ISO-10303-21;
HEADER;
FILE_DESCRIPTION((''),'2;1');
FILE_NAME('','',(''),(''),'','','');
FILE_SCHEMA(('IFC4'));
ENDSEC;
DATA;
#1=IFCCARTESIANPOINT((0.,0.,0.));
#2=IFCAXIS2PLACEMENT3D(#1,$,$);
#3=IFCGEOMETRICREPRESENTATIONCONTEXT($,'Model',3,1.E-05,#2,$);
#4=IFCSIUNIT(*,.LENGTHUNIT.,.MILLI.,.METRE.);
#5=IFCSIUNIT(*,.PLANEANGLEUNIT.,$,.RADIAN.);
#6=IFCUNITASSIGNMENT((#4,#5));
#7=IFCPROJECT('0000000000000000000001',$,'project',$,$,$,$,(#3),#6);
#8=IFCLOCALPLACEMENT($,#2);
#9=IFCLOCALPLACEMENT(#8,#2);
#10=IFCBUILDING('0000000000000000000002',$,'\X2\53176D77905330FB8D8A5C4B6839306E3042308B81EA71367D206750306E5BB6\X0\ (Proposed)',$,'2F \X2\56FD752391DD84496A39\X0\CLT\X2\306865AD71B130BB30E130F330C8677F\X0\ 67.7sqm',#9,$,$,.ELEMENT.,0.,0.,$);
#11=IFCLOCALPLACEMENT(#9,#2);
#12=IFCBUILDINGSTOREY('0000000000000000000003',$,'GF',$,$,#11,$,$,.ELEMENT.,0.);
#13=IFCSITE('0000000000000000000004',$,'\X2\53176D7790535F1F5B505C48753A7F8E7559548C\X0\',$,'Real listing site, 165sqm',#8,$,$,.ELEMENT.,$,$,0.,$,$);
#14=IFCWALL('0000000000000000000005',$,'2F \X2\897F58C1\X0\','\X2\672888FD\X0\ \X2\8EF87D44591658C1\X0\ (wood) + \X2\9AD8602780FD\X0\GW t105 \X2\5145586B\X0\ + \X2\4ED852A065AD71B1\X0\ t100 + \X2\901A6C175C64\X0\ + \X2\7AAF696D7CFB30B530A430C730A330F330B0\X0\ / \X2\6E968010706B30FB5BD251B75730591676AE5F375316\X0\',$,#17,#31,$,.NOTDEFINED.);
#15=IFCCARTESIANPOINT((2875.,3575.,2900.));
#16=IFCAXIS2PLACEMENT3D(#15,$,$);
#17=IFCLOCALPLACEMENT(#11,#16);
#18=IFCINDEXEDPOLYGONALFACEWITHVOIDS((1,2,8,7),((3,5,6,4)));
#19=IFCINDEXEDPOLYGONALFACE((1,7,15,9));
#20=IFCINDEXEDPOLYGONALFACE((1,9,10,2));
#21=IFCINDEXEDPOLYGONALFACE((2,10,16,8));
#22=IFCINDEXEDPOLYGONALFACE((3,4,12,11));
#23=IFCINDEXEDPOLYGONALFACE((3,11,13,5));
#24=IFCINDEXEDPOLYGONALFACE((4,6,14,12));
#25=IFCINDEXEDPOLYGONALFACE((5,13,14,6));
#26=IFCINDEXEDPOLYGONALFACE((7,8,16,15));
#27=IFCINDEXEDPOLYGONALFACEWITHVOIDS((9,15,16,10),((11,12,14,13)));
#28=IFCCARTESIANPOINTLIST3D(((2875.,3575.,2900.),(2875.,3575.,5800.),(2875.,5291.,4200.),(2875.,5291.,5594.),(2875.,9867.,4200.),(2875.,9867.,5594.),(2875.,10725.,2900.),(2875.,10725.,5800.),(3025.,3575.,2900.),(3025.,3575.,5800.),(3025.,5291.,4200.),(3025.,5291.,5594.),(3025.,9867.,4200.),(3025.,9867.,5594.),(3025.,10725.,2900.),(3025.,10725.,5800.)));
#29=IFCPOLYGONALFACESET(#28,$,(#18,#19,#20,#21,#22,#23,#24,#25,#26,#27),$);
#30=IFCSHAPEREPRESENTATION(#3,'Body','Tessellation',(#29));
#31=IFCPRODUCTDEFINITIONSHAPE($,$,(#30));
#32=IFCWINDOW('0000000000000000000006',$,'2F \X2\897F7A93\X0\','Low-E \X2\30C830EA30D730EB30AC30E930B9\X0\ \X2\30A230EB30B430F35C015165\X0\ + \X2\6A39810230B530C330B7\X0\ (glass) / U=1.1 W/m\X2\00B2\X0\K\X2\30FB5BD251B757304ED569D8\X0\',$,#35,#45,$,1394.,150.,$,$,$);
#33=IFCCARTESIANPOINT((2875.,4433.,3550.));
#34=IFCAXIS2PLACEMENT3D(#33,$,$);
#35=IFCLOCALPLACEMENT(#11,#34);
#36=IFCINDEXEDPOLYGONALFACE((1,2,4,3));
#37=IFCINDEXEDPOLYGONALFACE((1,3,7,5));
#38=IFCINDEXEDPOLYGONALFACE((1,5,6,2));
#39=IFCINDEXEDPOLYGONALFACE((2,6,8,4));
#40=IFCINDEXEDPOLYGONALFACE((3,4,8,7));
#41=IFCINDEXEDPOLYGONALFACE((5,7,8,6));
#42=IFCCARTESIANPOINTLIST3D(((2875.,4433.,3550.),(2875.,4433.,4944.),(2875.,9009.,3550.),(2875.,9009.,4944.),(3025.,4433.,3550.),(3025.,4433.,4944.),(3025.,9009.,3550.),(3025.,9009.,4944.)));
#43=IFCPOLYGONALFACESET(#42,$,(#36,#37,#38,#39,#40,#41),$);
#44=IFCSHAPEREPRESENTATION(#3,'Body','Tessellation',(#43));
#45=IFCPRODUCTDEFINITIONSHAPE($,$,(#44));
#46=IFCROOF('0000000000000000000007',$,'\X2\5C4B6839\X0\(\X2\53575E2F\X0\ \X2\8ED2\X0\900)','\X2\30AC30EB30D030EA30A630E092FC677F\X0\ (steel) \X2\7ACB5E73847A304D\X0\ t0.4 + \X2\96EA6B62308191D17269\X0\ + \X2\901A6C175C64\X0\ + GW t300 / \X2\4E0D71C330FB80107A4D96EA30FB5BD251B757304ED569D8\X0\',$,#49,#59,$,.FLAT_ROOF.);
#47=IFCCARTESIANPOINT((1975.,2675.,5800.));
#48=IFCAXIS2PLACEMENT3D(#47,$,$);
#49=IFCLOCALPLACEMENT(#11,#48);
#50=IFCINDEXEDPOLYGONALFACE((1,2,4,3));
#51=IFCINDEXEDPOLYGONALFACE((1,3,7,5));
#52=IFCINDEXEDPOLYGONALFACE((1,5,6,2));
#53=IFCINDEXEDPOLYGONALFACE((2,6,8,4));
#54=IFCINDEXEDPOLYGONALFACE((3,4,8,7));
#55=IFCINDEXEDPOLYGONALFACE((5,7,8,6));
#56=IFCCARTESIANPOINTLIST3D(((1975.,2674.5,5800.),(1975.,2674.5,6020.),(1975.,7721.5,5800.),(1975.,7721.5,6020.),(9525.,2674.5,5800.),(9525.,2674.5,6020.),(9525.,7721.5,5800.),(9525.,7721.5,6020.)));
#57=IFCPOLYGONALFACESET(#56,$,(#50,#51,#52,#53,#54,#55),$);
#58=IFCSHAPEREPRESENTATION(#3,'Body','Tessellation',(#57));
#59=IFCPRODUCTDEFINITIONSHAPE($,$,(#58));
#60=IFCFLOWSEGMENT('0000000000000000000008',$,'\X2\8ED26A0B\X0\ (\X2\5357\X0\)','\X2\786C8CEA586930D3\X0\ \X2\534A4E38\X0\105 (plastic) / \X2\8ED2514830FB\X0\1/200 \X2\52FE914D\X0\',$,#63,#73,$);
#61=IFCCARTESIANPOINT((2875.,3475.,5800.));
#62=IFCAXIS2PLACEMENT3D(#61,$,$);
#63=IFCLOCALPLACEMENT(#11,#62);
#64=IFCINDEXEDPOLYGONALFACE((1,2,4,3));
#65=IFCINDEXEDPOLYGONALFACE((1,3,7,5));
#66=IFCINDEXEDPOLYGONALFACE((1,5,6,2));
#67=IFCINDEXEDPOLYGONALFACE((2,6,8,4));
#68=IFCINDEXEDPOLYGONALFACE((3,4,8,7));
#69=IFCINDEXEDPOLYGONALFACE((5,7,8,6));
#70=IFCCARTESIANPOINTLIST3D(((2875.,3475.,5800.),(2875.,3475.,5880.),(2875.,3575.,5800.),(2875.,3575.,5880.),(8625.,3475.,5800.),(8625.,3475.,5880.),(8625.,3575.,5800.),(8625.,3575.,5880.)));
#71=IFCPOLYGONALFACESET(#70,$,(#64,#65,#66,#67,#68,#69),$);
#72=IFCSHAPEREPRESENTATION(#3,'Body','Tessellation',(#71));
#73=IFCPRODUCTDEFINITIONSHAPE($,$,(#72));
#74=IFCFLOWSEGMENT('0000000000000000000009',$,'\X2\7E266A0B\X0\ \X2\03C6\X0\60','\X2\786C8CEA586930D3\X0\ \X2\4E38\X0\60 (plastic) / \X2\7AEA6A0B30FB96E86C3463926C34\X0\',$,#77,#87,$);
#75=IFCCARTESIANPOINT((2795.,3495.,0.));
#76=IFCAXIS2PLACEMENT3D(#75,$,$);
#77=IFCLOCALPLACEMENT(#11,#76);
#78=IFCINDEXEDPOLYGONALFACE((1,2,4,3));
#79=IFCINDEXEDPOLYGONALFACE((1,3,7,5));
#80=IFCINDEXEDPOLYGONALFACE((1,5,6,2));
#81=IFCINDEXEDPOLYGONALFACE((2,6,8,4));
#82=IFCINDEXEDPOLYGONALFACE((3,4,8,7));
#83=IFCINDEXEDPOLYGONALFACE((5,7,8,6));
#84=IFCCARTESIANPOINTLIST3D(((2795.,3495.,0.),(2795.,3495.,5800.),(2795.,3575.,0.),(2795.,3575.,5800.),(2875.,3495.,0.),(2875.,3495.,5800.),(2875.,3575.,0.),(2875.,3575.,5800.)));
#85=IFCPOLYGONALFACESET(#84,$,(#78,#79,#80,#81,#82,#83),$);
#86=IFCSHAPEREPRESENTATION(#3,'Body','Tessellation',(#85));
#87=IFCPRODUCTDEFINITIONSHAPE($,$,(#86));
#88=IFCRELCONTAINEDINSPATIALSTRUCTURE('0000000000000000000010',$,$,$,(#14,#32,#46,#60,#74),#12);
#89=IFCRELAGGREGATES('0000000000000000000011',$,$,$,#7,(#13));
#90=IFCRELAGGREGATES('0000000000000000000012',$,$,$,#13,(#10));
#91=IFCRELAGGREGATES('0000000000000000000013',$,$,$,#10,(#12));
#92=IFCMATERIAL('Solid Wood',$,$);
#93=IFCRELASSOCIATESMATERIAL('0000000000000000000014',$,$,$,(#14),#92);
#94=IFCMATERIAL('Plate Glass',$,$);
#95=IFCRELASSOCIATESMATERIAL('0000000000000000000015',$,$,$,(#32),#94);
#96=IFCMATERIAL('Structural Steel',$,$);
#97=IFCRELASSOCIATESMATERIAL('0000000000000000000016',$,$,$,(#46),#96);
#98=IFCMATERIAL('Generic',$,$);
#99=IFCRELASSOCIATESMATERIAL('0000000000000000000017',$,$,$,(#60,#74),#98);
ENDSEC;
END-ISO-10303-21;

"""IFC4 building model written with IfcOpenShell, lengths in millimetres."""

from ifc_helpers import new_model, si_unit, frame, frame_2d, origin, place, context, project, spatial, rectangle, extrude, material, element, fill, save


model = new_model("IFC4")

# Units and contexts
model_context = context("Model", 3, precision=1e-05, world=origin())
ifc_project = project(units=[si_unit("LENGTHUNIT", "METRE", prefix="MILLI"), si_unit("PLANEANGLEUNIT", "RADIAN")], contexts=[model_context])

# Site, building, storey
site_placement = place(None, origin())
site = spatial("IfcSite", under=ifc_project, at=site_placement, Name="北海道弟子屈町美留和", ObjectType="Real listing site, 165sqm", CompositionType="ELEMENT", RefElevation=0.0)
building_placement = place(site_placement, origin())
building = spatial("IfcBuilding", under=site, at=building_placement, Name="北海道・越屋根のある自然素材の家 (Proposed)", ObjectType="2F 国産針葉樹CLTと断熱セメント板 67.7sqm", CompositionType="ELEMENT", ElevationOfRefHeight=0.0, ElevationOfTerrain=0.0)
storey_placement = place(building_placement, origin())
storey = spatial("IfcBuildingStorey", under=building, at=storey_placement, Name="GF", CompositionType="ELEMENT", Elevation=0.0)

# Shared definitions
ifc_material_1 = material(Name="Solid Wood")

# Shared definitions
ifc_material_2 = material(Name="Plate Glass")

# Wall, opening, window
wall_1_placement = place(storey_placement, frame((2875.0, 3575.0, 2900.0)))
wall_1 = element("IfcWall", 1, at=wall_1_placement, inside=storey, material=ifc_material_1, Name="2F 西壁", Description="木製 軸組外壁 (wood) + 高性能GW t105 充填 + 付加断熱 t100 + 通気層 + 窯業系サイディング / 準耐火・寒冷地外皮強化", PredefinedType="NOTDEFINED", context=model_context, shape_type="SweptSolid", body=[
    extrude(rectangle(XDim=150.0, YDim=7150.0, at=frame_2d((75.0, 3575.0))), frame((2875.0, 3575.0, 2900.0)), (0.0, 0.0, 1.0), 2900.0),
])
opening_1_placement = place(storey_placement, frame((2875.0, 4433.0, 3550.0)))
opening_1 = element("IfcOpeningElement", 2, at=opening_1_placement, cuts=wall_1, PredefinedType="NOTDEFINED", context=model_context, shape_type="SweptSolid", body=[
    extrude(rectangle(XDim=150.0, YDim=4576.0, at=frame_2d((75.0, 2288.0))), frame((2875.0, 4433.0, 3550.0)), (0.0, 0.0, 1.0), 1394.0),
])
window_1_placement = place(storey_placement, frame((2875.0, 4433.0, 3550.0)))
window_1 = element("IfcWindow", 3, at=window_1_placement, inside=storey, material=ifc_material_2, Name="2F 西窓", Description="Low-E トリプルガラス アルゴン封入 + 樹脂サッシ (glass) / U=1.1 W/m²K・寒冷地仕様", OverallHeight=1394.0, OverallWidth=150.0, context=model_context, shape_type="SweptSolid", body=[
    extrude(rectangle(XDim=150.0, YDim=4576.0, at=frame_2d((75.0, 2288.0))), frame((2875.0, 4433.0, 3550.0)), (0.0, 0.0, 1.0), 1394.0),
])
fill(opening_1, window_1)

# Roof
ifc_material_3 = material(Name="Structural Steel")
for number, where, name in (
    (4, (1975.0, 2675.0, 5800.0), "屋根(南帯 軒900)"),
):
    element("IfcRoof", number, at=place(storey_placement, frame(where)), inside=storey, material=ifc_material_3, Name=name, Description="ガルバリウム鋼板 (steel) 立平葺き t0.4 + 雪止め金物 + 通気層 + GW t300 / 不燃・耐積雪・寒冷地仕様", PredefinedType="FLAT_ROOF", context=model_context, shape_type="SweptSolid", body=[
        extrude(rectangle(XDim=7550.0, YDim=5047.0, at=frame_2d((3775.0, 2523.0))), frame((1975.0, 2675.0, 5800.0)), (0.0, 0.0, 1.0), 220.0),
    ])

# Flow segments
ifc_material_4 = material(Name="Generic")
flow_segment_1_placement = place(storey_placement, frame((2875.0, 3475.0, 5800.0)))
element("IfcFlowSegment", 5, at=flow_segment_1_placement, inside=storey, material=ifc_material_4, Name="軒樋 (南)", Description="硬質塩ビ 半丸105 (plastic) / 軒先・1/200 勾配", context=model_context, shape_type="SweptSolid", body=[
    extrude(rectangle(XDim=5750.0, YDim=100.0, at=frame_2d((2875.0, 50.0))), frame((2875.0, 3475.0, 5800.0)), (0.0, 0.0, 1.0), 80.0),
])
flow_segment_2_placement = place(storey_placement, frame((2795.0, 3495.0, 0.0)))
element("IfcFlowSegment", 6, at=flow_segment_2_placement, inside=storey, material=ifc_material_4, Name="縦樋 φ60", Description="硬質塩ビ 丸60 (plastic) / 竪樋・雨水排水", context=model_context, shape_type="SweptSolid", body=[
    extrude(rectangle(XDim=80.0, YDim=80.0, at=frame_2d((40.0, 40.0))), frame((2795.0, 3495.0, 0.0)), (0.0, 0.0, 1.0), 5800.0),
])

save(model, "model.ifc")
